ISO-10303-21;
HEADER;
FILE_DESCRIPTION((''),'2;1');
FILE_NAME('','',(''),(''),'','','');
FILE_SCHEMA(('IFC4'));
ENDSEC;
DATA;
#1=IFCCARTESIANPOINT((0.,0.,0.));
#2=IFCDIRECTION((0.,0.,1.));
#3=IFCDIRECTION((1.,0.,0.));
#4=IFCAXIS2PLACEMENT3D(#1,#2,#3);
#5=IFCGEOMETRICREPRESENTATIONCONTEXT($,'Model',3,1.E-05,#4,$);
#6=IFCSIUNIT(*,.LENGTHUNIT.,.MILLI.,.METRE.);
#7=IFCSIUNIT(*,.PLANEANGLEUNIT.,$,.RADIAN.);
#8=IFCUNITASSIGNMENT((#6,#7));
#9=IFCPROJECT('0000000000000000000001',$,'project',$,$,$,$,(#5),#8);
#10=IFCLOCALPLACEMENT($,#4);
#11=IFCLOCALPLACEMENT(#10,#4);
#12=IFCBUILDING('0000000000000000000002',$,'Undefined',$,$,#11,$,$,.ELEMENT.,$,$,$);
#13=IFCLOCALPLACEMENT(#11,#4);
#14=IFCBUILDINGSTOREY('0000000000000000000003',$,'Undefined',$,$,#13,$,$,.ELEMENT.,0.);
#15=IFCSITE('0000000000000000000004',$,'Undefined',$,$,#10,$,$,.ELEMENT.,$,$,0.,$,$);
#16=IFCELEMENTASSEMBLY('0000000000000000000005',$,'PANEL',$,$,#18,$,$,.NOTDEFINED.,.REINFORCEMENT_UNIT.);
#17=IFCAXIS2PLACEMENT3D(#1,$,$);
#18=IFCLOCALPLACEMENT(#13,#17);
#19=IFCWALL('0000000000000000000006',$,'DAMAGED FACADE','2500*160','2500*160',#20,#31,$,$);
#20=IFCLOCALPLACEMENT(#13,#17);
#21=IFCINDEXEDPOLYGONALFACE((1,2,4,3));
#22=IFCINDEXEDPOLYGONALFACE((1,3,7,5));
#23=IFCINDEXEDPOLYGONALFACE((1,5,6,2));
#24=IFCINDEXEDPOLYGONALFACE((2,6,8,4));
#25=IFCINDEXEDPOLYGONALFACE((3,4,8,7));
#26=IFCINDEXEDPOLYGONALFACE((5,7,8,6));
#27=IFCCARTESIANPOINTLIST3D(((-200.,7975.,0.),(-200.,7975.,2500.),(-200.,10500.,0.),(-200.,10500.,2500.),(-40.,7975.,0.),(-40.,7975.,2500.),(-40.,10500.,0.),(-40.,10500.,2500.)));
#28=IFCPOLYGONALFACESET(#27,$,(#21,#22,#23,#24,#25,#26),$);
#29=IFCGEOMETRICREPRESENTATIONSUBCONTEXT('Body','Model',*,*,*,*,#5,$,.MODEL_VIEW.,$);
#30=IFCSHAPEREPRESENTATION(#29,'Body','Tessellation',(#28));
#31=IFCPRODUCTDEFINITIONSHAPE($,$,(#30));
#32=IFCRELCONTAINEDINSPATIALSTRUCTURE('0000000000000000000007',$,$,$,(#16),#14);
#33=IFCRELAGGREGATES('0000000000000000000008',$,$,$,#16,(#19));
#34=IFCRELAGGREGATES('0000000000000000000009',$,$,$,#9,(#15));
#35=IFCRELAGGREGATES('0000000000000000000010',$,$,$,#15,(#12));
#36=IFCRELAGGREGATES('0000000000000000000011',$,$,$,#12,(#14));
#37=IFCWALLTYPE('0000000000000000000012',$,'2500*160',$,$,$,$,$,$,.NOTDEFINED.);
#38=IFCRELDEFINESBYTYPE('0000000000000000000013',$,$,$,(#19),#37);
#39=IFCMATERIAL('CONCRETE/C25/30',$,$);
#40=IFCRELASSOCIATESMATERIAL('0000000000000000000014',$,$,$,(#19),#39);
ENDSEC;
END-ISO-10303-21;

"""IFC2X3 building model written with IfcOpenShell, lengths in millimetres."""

from ifc_helpers import new_model, si_unit, frame, frame_2d, origin_with_axes, place, context, subcontext, project, spatial, rectangle, extrude, material, type_object, element, aggregate, save


model = new_model("IFC2X3")

# Units and contexts
model_context = context("Model", 3, precision=1e-05, world=origin_with_axes())
body_context = subcontext(model_context, "Body", "Model", "MODEL_VIEW")
ifc_project = project(units=[si_unit("LENGTHUNIT", "METRE", prefix="MILLI"), si_unit("PLANEANGLEUNIT", "RADIAN")], contexts=[model_context])

# Site, building, storey
site_placement = place(None, origin_with_axes())
site = spatial("IfcSite", under=ifc_project, at=site_placement, Name="Undefined", CompositionType="ELEMENT", RefElevation=0.0)
building_placement = place(site_placement, origin_with_axes())
building = spatial("IfcBuilding", under=site, at=building_placement, Name="Undefined", CompositionType="ELEMENT")
storey_placement = place(building_placement, origin_with_axes())
storey = spatial("IfcBuildingStorey", under=building, at=storey_placement, Name="Undefined", CompositionType="ELEMENT", Elevation=0.0)

# Shared definitions
ifc_material = material(Name="CONCRETE/C25/30")

# Element assembly, wall
assembly_1_placement = place(storey_placement, origin_with_axes())
assembly_1 = element("IfcElementAssembly", 1, at=assembly_1_placement, inside=storey, Name="PANEL", AssemblyPlace="NOTDEFINED", PredefinedType="REINFORCEMENT_UNIT")
wall_type_1 = type_object("IfcWallType", Name="2500*160", PredefinedType="NOTDEFINED")
wall_1_placement = place(assembly_1_placement, frame((-120.0, 10500.0, 0.0), z_axis=(0.0, 0.0, 1.0), x_axis=(0.0, -1.0, 0.0)))
wall_1 = element("IfcWall", 2, at=wall_1_placement, type_object=wall_type_1, material=ifc_material, Name="DAMAGED FACADE", Description="2500*160", ObjectType="2500*160", context=body_context, shape_type="SweptSolid", body=[
    extrude(rectangle(XDim=2525.0, YDim=160.0, at=frame_2d((0.0, 1262.5), x_axis=(0.0, -1.0))), frame((0.0, 0.0, 0.0), z_axis=(0.0, 0.0, 1.0), x_axis=(0.0, -1.0, 0.0)), (0.0, 0.0, 1.0), 2500.0),
])
aggregate(assembly_1, [wall_1])

save(model, "model.ifc")
